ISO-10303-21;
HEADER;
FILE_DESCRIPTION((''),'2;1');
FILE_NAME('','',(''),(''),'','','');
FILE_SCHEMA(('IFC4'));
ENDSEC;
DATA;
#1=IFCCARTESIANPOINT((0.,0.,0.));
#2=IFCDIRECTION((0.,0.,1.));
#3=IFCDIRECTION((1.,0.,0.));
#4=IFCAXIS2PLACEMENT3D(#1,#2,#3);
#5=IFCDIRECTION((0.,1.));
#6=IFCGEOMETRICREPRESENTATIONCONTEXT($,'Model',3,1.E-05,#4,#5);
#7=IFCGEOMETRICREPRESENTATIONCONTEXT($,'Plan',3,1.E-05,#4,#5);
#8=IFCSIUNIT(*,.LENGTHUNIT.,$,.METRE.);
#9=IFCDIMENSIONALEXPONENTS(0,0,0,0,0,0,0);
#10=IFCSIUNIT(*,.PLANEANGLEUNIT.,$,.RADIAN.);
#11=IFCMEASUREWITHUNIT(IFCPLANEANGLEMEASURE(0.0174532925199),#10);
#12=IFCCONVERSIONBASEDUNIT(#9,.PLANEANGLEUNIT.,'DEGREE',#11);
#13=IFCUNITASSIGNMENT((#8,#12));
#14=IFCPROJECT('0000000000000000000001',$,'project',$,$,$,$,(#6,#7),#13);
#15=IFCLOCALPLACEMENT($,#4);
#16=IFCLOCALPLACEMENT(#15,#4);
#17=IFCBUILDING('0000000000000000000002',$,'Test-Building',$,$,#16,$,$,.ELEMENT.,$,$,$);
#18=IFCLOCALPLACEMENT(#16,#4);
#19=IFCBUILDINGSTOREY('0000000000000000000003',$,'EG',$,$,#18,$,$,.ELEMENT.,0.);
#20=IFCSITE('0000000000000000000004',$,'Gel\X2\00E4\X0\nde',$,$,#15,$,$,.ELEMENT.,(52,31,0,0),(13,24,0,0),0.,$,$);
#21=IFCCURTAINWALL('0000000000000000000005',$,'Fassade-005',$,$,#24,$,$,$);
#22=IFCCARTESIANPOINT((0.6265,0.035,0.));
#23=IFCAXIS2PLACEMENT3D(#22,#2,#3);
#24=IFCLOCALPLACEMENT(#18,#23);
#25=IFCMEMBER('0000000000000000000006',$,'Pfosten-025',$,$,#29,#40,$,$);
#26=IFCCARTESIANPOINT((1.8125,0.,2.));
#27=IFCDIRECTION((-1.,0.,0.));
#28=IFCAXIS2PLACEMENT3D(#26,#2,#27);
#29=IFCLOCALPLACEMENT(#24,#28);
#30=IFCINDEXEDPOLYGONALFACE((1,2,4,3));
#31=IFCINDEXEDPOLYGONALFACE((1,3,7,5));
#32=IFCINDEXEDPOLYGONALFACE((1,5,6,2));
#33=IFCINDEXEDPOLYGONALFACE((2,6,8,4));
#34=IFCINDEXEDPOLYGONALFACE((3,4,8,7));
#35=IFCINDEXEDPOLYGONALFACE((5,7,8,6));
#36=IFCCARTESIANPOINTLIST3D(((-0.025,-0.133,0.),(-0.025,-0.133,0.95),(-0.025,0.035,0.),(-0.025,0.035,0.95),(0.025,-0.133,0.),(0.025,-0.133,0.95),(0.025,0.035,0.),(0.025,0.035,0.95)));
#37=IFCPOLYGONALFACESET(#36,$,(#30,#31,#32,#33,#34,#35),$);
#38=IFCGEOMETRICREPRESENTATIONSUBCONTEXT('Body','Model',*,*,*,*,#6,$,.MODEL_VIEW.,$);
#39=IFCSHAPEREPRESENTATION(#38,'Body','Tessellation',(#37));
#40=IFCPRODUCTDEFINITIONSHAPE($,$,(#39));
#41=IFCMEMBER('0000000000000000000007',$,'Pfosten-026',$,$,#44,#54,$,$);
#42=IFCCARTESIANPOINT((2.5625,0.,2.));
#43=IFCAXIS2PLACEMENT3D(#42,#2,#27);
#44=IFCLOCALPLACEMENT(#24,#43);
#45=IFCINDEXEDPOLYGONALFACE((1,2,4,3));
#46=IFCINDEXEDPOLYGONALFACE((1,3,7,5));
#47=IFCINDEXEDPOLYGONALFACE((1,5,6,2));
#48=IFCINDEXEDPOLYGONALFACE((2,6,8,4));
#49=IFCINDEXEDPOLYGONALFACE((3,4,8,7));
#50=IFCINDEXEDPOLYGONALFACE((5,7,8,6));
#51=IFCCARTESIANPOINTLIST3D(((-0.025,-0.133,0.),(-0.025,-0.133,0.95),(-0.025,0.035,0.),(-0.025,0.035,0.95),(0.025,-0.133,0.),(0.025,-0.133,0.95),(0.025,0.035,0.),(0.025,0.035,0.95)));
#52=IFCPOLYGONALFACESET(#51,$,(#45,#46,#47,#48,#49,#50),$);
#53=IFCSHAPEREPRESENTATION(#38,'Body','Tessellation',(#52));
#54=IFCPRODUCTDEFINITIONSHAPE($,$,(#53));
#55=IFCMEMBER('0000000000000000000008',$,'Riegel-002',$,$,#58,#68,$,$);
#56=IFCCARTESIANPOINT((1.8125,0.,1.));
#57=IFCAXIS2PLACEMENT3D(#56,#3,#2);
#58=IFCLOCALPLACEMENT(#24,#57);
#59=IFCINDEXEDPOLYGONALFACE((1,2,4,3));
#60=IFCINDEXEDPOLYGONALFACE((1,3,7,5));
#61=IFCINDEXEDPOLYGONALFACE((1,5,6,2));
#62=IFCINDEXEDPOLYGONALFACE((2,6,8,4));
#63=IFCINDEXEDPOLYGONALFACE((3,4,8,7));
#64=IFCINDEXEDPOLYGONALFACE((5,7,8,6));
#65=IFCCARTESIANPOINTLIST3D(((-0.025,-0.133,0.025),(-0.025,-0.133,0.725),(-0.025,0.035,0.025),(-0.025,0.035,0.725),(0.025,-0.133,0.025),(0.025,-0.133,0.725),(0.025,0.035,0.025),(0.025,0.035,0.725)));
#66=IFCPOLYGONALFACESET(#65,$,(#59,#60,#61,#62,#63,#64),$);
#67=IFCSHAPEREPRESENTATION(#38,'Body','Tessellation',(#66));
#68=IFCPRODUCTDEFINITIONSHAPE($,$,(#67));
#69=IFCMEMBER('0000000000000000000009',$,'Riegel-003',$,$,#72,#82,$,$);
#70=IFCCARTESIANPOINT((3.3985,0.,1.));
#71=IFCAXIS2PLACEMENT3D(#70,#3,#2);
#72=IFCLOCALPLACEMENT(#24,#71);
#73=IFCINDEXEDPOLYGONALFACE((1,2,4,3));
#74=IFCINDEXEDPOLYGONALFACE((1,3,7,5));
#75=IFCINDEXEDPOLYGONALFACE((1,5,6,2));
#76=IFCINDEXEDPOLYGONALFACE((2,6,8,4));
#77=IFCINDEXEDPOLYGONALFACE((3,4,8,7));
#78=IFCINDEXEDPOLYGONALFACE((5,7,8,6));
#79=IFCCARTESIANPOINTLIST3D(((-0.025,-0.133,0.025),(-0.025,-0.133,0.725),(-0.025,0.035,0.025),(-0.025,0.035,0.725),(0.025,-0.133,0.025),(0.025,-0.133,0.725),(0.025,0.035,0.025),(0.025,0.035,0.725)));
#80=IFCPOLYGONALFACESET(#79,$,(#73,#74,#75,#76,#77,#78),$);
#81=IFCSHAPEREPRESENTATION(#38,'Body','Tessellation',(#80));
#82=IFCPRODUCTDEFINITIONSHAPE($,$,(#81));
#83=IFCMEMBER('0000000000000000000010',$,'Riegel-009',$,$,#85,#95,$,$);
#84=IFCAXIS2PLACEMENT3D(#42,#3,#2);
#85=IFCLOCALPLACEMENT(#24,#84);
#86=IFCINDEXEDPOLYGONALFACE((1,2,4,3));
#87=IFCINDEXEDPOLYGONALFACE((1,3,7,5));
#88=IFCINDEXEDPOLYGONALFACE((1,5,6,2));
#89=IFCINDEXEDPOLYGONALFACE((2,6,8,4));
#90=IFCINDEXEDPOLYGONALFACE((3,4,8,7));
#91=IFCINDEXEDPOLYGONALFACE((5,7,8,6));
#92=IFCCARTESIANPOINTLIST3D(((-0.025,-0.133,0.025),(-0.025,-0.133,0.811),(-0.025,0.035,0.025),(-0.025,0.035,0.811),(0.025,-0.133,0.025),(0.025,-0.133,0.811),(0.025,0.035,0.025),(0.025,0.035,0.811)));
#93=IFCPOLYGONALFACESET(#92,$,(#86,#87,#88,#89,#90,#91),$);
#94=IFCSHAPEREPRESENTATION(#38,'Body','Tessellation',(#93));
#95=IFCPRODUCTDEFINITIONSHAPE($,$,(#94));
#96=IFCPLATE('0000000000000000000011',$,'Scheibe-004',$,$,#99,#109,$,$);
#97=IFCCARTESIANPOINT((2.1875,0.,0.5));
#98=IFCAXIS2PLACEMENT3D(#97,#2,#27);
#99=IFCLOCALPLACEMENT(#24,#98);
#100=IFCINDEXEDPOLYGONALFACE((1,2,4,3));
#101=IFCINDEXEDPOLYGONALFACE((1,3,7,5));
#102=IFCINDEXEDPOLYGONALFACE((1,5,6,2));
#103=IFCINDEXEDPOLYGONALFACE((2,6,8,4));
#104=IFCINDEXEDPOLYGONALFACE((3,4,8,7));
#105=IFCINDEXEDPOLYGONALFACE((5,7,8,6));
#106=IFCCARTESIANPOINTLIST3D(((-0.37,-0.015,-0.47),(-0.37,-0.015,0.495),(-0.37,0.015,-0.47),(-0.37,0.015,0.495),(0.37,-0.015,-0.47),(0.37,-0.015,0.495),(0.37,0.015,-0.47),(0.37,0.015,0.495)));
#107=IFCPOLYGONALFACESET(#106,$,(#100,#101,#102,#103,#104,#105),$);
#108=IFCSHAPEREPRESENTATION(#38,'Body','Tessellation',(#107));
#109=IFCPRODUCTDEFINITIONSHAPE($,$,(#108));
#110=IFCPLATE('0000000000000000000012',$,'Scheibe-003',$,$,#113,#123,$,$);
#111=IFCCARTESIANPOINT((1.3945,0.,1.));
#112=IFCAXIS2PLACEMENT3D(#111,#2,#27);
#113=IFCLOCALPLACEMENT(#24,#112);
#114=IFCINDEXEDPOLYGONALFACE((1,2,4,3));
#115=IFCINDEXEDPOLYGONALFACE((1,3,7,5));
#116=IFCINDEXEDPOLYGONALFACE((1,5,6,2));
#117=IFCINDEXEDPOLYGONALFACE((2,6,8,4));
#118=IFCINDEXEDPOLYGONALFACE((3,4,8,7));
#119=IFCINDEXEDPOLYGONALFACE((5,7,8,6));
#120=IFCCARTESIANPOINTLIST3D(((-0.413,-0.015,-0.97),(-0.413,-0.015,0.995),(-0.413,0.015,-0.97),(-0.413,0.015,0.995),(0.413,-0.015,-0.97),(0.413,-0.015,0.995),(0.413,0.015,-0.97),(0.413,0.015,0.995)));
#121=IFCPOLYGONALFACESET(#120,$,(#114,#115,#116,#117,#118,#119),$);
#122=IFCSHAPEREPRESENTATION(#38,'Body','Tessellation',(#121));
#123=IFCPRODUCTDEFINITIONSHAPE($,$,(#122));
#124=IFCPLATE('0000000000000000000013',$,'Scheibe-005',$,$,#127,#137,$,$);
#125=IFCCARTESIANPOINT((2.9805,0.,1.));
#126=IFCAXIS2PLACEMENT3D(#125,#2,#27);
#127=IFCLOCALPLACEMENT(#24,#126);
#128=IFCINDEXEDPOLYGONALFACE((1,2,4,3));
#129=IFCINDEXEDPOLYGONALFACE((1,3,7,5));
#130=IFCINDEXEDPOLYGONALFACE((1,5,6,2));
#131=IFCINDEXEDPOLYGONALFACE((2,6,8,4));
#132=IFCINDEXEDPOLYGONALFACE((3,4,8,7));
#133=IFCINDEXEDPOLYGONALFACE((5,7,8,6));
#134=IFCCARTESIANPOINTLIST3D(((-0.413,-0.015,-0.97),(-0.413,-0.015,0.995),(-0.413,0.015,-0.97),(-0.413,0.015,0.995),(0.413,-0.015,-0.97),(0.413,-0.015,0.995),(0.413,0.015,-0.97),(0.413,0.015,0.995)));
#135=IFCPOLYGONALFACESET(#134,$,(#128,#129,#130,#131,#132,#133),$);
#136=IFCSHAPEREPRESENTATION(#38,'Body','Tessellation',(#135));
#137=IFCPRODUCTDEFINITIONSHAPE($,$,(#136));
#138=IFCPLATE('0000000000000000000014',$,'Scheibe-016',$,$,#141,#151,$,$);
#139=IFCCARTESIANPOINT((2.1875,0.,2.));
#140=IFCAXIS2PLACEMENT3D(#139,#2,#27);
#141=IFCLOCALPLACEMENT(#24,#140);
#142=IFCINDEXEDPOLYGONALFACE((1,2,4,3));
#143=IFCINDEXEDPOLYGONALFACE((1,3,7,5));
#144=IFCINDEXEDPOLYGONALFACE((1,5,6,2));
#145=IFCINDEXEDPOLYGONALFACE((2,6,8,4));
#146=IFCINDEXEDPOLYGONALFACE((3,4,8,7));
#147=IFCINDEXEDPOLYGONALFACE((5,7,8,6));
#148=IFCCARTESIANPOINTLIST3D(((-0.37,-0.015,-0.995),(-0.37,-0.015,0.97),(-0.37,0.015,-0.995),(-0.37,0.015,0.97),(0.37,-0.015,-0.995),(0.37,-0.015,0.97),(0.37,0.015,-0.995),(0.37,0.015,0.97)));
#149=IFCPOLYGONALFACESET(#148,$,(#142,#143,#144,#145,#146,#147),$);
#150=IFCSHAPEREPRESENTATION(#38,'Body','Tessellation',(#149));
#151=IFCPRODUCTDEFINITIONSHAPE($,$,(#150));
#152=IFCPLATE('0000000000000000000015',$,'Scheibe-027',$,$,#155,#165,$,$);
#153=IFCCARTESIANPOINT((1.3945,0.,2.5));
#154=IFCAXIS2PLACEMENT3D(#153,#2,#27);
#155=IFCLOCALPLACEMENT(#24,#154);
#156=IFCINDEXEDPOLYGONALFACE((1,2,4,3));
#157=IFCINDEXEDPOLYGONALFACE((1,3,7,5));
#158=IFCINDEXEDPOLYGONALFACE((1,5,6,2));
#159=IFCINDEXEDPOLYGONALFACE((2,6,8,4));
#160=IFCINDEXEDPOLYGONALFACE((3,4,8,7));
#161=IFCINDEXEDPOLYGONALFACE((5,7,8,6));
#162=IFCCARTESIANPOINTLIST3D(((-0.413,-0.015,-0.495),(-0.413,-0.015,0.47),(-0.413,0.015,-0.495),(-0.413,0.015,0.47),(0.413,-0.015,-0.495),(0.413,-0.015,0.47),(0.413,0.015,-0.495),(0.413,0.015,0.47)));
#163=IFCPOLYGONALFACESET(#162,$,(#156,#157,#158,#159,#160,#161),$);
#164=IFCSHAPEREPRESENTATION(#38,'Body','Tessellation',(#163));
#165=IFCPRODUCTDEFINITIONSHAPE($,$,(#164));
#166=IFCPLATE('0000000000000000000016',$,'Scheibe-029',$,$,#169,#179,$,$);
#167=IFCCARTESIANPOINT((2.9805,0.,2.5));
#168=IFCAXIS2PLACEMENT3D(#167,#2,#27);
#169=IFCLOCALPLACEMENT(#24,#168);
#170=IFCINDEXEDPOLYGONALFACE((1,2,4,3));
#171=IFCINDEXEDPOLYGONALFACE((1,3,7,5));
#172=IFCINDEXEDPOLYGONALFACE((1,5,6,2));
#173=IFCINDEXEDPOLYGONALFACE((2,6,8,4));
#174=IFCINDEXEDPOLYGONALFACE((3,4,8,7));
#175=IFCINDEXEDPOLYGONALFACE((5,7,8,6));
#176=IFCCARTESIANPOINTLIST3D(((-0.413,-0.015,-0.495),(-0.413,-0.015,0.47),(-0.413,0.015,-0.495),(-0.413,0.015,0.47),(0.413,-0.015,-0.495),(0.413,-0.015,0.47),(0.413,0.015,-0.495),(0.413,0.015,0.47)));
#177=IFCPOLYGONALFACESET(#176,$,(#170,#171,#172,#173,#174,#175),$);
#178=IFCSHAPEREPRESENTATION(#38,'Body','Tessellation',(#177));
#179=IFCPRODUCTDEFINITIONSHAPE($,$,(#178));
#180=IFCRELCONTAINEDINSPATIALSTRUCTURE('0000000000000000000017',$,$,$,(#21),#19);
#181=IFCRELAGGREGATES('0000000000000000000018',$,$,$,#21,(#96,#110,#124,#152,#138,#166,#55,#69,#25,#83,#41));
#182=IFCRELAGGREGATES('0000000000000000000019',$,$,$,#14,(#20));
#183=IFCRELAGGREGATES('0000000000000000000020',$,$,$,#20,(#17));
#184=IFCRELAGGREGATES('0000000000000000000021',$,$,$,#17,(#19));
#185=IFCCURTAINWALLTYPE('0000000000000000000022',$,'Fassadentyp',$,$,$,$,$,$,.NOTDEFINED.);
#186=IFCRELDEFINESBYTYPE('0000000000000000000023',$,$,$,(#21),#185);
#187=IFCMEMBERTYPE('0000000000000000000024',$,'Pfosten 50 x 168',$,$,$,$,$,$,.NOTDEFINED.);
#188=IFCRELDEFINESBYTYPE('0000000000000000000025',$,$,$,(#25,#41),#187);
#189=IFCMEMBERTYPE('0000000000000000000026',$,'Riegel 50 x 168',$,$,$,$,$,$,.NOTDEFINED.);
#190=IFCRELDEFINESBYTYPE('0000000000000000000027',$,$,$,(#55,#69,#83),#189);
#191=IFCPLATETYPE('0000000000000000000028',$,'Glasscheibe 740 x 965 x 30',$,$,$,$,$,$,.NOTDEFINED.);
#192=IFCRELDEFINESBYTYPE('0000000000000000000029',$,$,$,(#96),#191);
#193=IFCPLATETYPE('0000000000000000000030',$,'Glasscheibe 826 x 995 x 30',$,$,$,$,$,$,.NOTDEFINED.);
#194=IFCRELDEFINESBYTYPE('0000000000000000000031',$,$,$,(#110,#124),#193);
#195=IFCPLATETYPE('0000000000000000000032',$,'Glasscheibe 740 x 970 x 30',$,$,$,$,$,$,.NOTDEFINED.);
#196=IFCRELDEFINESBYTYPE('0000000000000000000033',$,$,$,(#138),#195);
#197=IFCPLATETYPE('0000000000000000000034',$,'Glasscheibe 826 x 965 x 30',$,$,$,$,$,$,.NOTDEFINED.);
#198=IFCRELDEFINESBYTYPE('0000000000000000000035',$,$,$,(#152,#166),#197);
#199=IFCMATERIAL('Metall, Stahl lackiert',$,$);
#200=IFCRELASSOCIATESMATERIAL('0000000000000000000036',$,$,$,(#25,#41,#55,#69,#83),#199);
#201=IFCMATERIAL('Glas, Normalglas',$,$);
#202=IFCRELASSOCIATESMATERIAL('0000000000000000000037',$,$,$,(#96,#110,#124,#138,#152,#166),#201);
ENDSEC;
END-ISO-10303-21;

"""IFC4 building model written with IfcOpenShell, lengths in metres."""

from ifc_helpers import new_model, entity, si_unit, converted_unit, direction, frame, origin_with_axes, place, context, subcontext, project, spatial, polyline, outline, extrude, material, type_object, element, aggregate, save


model = new_model("IFC4")

# Units and contexts
model_context = context("Model", 3, precision=1e-05, world=origin_with_axes(), true_north=direction((0.0, 1.0)))
plan_context = context("Plan", 3, precision=1e-05, world=origin_with_axes(), true_north=direction((0.0, 1.0)))
body_context = subcontext(model_context, "Body", "Model", "MODEL_VIEW")
ifc_project = project(units=[si_unit("LENGTHUNIT", "METRE"), converted_unit("PLANEANGLEUNIT", "DEGREE", entity("IfcPlaneAngleMeasure", 0.0174532925199), si_unit("PLANEANGLEUNIT", "RADIAN"), dimensions=[0, 0, 0, 0, 0, 0, 0])], contexts=[model_context, plan_context])

# Site, building, storey
site_placement = place(None, origin_with_axes())
site = spatial("IfcSite", under=ifc_project, at=site_placement, Name="Gelände", CompositionType="ELEMENT", RefLatitude=(52, 31, 0, 0), RefLongitude=(13, 24, 0, 0), RefElevation=0.0)
building_placement = place(site_placement, origin_with_axes())
building = spatial("IfcBuilding", under=site, at=building_placement, Name="Test-Building", CompositionType="ELEMENT")
storey_placement = place(building_placement, origin_with_axes())
storey = spatial("IfcBuildingStorey", under=building, at=storey_placement, Name="EG", CompositionType="ELEMENT", Elevation=0.0)

# Curtain wall, members, plates
curtain_wall_type = type_object("IfcCurtainWallType", Name="Fassadentyp", PredefinedType="NOTDEFINED")
curtain_wall_placement = place(storey_placement, frame((0.6265, 0.035, 0.0), z_axis=(0.0, 0.0, 1.0), x_axis=(1.0, 0.0, 0.0)))
curtain_wall = element("IfcCurtainWall", 1, at=curtain_wall_placement, inside=storey, type_object=curtain_wall_type, Name="Fassade-005")
ifc_material_1 = material(Name="Metall, Stahl lackiert")
member_type_1 = type_object("IfcMemberType", Name="Pfosten 50 x 168", PredefinedType="NOTDEFINED")
member_1_placement = place(curtain_wall_placement, frame((1.8125, 0.0, 2.0), z_axis=(0.0, 0.0, 1.0), x_axis=(-1.0, 0.0, 0.0)))
member_1 = element("IfcMember", 2, at=member_1_placement, type_object=member_type_1, material=ifc_material_1, Name="Pfosten-025", context=body_context, shape_type="SweptSolid", body=[
    extrude(outline(polyline([(-0.025, 0.133), (-0.025, -0.035), (0.025, -0.035), (0.025, 0.133), (-0.025, 0.133)])), frame((0.0, 0.0, 0.0), z_axis=(0.0, 0.0, 1.0), x_axis=(-1.0, 0.0, 0.0)), (0.0, 0.0, 1.0), 0.95),
])
member_2_placement = place(curtain_wall_placement, frame((2.5625, 0.0, 2.0), z_axis=(0.0, 0.0, 1.0), x_axis=(-1.0, 0.0, 0.0)))
member_2 = element("IfcMember", 3, at=member_2_placement, type_object=member_type_1, material=ifc_material_1, Name="Pfosten-026", context=body_context, shape_type="SweptSolid", body=[
    extrude(outline(polyline([(-0.025, 0.133), (-0.025, -0.035), (0.025, -0.035), (0.025, 0.133), (-0.025, 0.133)])), frame((0.0, 0.0, 0.0), z_axis=(0.0, 0.0, 1.0), x_axis=(-1.0, 0.0, 0.0)), (0.0, 0.0, 1.0), 0.95),
])
member_type_2 = type_object("IfcMemberType", Name="Riegel 50 x 168", PredefinedType="NOTDEFINED")
member_3_placement = place(curtain_wall_placement, frame((1.8125, 0.0, 1.0), z_axis=(1.0, 0.0, 0.0), x_axis=(0.0, 0.0, 1.0)))
member_3 = element("IfcMember", 4, at=member_3_placement, type_object=member_type_2, material=ifc_material_1, Name="Riegel-002", context=body_context, shape_type="SweptSolid", body=[
    extrude(outline(polyline([(-0.133, -0.025), (0.035, -0.025), (0.035, 0.025), (-0.133, 0.025), (-0.133, -0.025)])), frame((0.0, 0.0, 0.025), z_axis=(0.0, 0.0, 1.0), x_axis=(0.0, 1.0, 0.0)), (0.0, 0.0, 1.0), 0.7),
])
member_4_placement = place(curtain_wall_placement, frame((3.3985, 0.0, 1.0), z_axis=(1.0, 0.0, 0.0), x_axis=(0.0, 0.0, 1.0)))
member_4 = element("IfcMember", 5, at=member_4_placement, type_object=member_type_2, material=ifc_material_1, Name="Riegel-003", context=body_context, shape_type="SweptSolid", body=[
    extrude(outline(polyline([(-0.133, -0.025), (0.035, -0.025), (0.035, 0.025), (-0.133, 0.025), (-0.133, -0.025)])), frame((0.0, 0.0, 0.025), z_axis=(0.0, 0.0, 1.0), x_axis=(0.0, 1.0, 0.0)), (0.0, 0.0, 1.0), 0.7),
])
member_5_placement = place(curtain_wall_placement, frame((2.5625, 0.0, 2.0), z_axis=(1.0, 0.0, 0.0), x_axis=(0.0, 0.0, 1.0)))
member_5 = element("IfcMember", 6, at=member_5_placement, type_object=member_type_2, material=ifc_material_1, Name="Riegel-009", context=body_context, shape_type="SweptSolid", body=[
    extrude(outline(polyline([(-0.133, -0.025), (0.035, -0.025), (0.035, 0.025), (-0.133, 0.025), (-0.133, -0.025)])), frame((0.0, 0.0, 0.025), z_axis=(0.0, 0.0, 1.0), x_axis=(0.0, 1.0, 0.0)), (0.0, 0.0, 1.0), 0.786),
])
ifc_material_2 = material(Name="Glas, Normalglas")
plate_type_1 = type_object("IfcPlateType", Name="Glasscheibe 740 x 965 x 30", PredefinedType="NOTDEFINED")
plate_1_placement = place(curtain_wall_placement, frame((2.1875, 0.0, 0.5), z_axis=(0.0, 0.0, 1.0), x_axis=(-1.0, 0.0, 0.0)))
plate_1 = element("IfcPlate", 7, at=plate_1_placement, type_object=plate_type_1, material=ifc_material_2, Name="Scheibe-004", context=body_context, shape_type="SweptSolid", body=[
    extrude(outline(polyline([(-0.37, -0.495), (0.37, -0.495), (0.37, 0.47), (-0.37, 0.47), (-0.37, -0.495)])), frame((0.0, -0.015, 0.0), z_axis=(0.0, 1.0, 0.0), x_axis=(1.0, 0.0, 0.0)), (0.0, 0.0, 1.0), 0.03),
])
plate_type_2 = type_object("IfcPlateType", Name="Glasscheibe 826 x 995 x 30", PredefinedType="NOTDEFINED")
plate_2_placement = place(curtain_wall_placement, frame((1.3945, 0.0, 1.0), z_axis=(0.0, 0.0, 1.0), x_axis=(-1.0, 0.0, 0.0)))
plate_2 = element("IfcPlate", 8, at=plate_2_placement, type_object=plate_type_2, material=ifc_material_2, Name="Scheibe-003", context=body_context, shape_type="SweptSolid", body=[
    extrude(outline(polyline([(-0.413, -0.995), (0.413, -0.995), (0.413, 0.97), (-0.413, 0.97), (-0.413, -0.995)])), frame((0.0, -0.015, 0.0), z_axis=(0.0, 1.0, 0.0), x_axis=(1.0, 0.0, 0.0)), (0.0, 0.0, 1.0), 0.03),
])
plate_3_placement = place(curtain_wall_placement, frame((2.9805, 0.0, 1.0), z_axis=(0.0, 0.0, 1.0), x_axis=(-1.0, 0.0, 0.0)))
plate_3 = element("IfcPlate", 9, at=plate_3_placement, type_object=plate_type_2, material=ifc_material_2, Name="Scheibe-005", context=body_context, shape_type="SweptSolid", body=[
    extrude(outline(polyline([(-0.413, -0.995), (0.413, -0.995), (0.413, 0.97), (-0.413, 0.97), (-0.413, -0.995)])), frame((0.0, -0.015, 0.0), z_axis=(0.0, 1.0, 0.0), x_axis=(1.0, 0.0, 0.0)), (0.0, 0.0, 1.0), 0.03),
])
plate_type_3 = type_object("IfcPlateType", Name="Glasscheibe 740 x 970 x 30", PredefinedType="NOTDEFINED")
plate_4_placement = place(curtain_wall_placement, frame((2.1875, 0.0, 2.0), z_axis=(0.0, 0.0, 1.0), x_axis=(-1.0, 0.0, 0.0)))
plate_4 = element("IfcPlate", 10, at=plate_4_placement, type_object=plate_type_3, material=ifc_material_2, Name="Scheibe-016", context=body_context, shape_type="SweptSolid", body=[
    extrude(outline(polyline([(-0.37, -0.97), (0.37, -0.97), (0.37, 0.995), (-0.37, 0.995), (-0.37, -0.97)])), frame((0.0, -0.015, 0.0), z_axis=(0.0, 1.0, 0.0), x_axis=(1.0, 0.0, 0.0)), (0.0, 0.0, 1.0), 0.03),
])
plate_type_4 = type_object("IfcPlateType", Name="Glasscheibe 826 x 965 x 30", PredefinedType="NOTDEFINED")
plate_5_placement = place(curtain_wall_placement, frame((1.3945, 0.0, 2.5), z_axis=(0.0, 0.0, 1.0), x_axis=(-1.0, 0.0, 0.0)))
plate_5 = element("IfcPlate", 11, at=plate_5_placement, type_object=plate_type_4, material=ifc_material_2, Name="Scheibe-027", context=body_context, shape_type="SweptSolid", body=[
    extrude(outline(polyline([(-0.413, -0.47), (0.413, -0.47), (0.413, 0.495), (-0.413, 0.495), (-0.413, -0.47)])), frame((0.0, -0.015, 0.0), z_axis=(0.0, 1.0, 0.0), x_axis=(1.0, 0.0, 0.0)), (0.0, 0.0, 1.0), 0.03),
])
plate_6_placement = place(curtain_wall_placement, frame((2.9805, 0.0, 2.5), z_axis=(0.0, 0.0, 1.0), x_axis=(-1.0, 0.0, 0.0)))
plate_6 = element("IfcPlate", 12, at=plate_6_placement, type_object=plate_type_4, material=ifc_material_2, Name="Scheibe-029", context=body_context, shape_type="SweptSolid", body=[
    extrude(outline(polyline([(-0.413, -0.47), (0.413, -0.47), (0.413, 0.495), (-0.413, 0.495), (-0.413, -0.47)])), frame((0.0, -0.015, 0.0), z_axis=(0.0, 1.0, 0.0), x_axis=(1.0, 0.0, 0.0)), (0.0, 0.0, 1.0), 0.03),
])
aggregate(curtain_wall, [plate_1, plate_2, plate_3, plate_5, plate_4, plate_6, member_3, member_4, member_1, member_5, member_2])

save(model, "model.ifc")
